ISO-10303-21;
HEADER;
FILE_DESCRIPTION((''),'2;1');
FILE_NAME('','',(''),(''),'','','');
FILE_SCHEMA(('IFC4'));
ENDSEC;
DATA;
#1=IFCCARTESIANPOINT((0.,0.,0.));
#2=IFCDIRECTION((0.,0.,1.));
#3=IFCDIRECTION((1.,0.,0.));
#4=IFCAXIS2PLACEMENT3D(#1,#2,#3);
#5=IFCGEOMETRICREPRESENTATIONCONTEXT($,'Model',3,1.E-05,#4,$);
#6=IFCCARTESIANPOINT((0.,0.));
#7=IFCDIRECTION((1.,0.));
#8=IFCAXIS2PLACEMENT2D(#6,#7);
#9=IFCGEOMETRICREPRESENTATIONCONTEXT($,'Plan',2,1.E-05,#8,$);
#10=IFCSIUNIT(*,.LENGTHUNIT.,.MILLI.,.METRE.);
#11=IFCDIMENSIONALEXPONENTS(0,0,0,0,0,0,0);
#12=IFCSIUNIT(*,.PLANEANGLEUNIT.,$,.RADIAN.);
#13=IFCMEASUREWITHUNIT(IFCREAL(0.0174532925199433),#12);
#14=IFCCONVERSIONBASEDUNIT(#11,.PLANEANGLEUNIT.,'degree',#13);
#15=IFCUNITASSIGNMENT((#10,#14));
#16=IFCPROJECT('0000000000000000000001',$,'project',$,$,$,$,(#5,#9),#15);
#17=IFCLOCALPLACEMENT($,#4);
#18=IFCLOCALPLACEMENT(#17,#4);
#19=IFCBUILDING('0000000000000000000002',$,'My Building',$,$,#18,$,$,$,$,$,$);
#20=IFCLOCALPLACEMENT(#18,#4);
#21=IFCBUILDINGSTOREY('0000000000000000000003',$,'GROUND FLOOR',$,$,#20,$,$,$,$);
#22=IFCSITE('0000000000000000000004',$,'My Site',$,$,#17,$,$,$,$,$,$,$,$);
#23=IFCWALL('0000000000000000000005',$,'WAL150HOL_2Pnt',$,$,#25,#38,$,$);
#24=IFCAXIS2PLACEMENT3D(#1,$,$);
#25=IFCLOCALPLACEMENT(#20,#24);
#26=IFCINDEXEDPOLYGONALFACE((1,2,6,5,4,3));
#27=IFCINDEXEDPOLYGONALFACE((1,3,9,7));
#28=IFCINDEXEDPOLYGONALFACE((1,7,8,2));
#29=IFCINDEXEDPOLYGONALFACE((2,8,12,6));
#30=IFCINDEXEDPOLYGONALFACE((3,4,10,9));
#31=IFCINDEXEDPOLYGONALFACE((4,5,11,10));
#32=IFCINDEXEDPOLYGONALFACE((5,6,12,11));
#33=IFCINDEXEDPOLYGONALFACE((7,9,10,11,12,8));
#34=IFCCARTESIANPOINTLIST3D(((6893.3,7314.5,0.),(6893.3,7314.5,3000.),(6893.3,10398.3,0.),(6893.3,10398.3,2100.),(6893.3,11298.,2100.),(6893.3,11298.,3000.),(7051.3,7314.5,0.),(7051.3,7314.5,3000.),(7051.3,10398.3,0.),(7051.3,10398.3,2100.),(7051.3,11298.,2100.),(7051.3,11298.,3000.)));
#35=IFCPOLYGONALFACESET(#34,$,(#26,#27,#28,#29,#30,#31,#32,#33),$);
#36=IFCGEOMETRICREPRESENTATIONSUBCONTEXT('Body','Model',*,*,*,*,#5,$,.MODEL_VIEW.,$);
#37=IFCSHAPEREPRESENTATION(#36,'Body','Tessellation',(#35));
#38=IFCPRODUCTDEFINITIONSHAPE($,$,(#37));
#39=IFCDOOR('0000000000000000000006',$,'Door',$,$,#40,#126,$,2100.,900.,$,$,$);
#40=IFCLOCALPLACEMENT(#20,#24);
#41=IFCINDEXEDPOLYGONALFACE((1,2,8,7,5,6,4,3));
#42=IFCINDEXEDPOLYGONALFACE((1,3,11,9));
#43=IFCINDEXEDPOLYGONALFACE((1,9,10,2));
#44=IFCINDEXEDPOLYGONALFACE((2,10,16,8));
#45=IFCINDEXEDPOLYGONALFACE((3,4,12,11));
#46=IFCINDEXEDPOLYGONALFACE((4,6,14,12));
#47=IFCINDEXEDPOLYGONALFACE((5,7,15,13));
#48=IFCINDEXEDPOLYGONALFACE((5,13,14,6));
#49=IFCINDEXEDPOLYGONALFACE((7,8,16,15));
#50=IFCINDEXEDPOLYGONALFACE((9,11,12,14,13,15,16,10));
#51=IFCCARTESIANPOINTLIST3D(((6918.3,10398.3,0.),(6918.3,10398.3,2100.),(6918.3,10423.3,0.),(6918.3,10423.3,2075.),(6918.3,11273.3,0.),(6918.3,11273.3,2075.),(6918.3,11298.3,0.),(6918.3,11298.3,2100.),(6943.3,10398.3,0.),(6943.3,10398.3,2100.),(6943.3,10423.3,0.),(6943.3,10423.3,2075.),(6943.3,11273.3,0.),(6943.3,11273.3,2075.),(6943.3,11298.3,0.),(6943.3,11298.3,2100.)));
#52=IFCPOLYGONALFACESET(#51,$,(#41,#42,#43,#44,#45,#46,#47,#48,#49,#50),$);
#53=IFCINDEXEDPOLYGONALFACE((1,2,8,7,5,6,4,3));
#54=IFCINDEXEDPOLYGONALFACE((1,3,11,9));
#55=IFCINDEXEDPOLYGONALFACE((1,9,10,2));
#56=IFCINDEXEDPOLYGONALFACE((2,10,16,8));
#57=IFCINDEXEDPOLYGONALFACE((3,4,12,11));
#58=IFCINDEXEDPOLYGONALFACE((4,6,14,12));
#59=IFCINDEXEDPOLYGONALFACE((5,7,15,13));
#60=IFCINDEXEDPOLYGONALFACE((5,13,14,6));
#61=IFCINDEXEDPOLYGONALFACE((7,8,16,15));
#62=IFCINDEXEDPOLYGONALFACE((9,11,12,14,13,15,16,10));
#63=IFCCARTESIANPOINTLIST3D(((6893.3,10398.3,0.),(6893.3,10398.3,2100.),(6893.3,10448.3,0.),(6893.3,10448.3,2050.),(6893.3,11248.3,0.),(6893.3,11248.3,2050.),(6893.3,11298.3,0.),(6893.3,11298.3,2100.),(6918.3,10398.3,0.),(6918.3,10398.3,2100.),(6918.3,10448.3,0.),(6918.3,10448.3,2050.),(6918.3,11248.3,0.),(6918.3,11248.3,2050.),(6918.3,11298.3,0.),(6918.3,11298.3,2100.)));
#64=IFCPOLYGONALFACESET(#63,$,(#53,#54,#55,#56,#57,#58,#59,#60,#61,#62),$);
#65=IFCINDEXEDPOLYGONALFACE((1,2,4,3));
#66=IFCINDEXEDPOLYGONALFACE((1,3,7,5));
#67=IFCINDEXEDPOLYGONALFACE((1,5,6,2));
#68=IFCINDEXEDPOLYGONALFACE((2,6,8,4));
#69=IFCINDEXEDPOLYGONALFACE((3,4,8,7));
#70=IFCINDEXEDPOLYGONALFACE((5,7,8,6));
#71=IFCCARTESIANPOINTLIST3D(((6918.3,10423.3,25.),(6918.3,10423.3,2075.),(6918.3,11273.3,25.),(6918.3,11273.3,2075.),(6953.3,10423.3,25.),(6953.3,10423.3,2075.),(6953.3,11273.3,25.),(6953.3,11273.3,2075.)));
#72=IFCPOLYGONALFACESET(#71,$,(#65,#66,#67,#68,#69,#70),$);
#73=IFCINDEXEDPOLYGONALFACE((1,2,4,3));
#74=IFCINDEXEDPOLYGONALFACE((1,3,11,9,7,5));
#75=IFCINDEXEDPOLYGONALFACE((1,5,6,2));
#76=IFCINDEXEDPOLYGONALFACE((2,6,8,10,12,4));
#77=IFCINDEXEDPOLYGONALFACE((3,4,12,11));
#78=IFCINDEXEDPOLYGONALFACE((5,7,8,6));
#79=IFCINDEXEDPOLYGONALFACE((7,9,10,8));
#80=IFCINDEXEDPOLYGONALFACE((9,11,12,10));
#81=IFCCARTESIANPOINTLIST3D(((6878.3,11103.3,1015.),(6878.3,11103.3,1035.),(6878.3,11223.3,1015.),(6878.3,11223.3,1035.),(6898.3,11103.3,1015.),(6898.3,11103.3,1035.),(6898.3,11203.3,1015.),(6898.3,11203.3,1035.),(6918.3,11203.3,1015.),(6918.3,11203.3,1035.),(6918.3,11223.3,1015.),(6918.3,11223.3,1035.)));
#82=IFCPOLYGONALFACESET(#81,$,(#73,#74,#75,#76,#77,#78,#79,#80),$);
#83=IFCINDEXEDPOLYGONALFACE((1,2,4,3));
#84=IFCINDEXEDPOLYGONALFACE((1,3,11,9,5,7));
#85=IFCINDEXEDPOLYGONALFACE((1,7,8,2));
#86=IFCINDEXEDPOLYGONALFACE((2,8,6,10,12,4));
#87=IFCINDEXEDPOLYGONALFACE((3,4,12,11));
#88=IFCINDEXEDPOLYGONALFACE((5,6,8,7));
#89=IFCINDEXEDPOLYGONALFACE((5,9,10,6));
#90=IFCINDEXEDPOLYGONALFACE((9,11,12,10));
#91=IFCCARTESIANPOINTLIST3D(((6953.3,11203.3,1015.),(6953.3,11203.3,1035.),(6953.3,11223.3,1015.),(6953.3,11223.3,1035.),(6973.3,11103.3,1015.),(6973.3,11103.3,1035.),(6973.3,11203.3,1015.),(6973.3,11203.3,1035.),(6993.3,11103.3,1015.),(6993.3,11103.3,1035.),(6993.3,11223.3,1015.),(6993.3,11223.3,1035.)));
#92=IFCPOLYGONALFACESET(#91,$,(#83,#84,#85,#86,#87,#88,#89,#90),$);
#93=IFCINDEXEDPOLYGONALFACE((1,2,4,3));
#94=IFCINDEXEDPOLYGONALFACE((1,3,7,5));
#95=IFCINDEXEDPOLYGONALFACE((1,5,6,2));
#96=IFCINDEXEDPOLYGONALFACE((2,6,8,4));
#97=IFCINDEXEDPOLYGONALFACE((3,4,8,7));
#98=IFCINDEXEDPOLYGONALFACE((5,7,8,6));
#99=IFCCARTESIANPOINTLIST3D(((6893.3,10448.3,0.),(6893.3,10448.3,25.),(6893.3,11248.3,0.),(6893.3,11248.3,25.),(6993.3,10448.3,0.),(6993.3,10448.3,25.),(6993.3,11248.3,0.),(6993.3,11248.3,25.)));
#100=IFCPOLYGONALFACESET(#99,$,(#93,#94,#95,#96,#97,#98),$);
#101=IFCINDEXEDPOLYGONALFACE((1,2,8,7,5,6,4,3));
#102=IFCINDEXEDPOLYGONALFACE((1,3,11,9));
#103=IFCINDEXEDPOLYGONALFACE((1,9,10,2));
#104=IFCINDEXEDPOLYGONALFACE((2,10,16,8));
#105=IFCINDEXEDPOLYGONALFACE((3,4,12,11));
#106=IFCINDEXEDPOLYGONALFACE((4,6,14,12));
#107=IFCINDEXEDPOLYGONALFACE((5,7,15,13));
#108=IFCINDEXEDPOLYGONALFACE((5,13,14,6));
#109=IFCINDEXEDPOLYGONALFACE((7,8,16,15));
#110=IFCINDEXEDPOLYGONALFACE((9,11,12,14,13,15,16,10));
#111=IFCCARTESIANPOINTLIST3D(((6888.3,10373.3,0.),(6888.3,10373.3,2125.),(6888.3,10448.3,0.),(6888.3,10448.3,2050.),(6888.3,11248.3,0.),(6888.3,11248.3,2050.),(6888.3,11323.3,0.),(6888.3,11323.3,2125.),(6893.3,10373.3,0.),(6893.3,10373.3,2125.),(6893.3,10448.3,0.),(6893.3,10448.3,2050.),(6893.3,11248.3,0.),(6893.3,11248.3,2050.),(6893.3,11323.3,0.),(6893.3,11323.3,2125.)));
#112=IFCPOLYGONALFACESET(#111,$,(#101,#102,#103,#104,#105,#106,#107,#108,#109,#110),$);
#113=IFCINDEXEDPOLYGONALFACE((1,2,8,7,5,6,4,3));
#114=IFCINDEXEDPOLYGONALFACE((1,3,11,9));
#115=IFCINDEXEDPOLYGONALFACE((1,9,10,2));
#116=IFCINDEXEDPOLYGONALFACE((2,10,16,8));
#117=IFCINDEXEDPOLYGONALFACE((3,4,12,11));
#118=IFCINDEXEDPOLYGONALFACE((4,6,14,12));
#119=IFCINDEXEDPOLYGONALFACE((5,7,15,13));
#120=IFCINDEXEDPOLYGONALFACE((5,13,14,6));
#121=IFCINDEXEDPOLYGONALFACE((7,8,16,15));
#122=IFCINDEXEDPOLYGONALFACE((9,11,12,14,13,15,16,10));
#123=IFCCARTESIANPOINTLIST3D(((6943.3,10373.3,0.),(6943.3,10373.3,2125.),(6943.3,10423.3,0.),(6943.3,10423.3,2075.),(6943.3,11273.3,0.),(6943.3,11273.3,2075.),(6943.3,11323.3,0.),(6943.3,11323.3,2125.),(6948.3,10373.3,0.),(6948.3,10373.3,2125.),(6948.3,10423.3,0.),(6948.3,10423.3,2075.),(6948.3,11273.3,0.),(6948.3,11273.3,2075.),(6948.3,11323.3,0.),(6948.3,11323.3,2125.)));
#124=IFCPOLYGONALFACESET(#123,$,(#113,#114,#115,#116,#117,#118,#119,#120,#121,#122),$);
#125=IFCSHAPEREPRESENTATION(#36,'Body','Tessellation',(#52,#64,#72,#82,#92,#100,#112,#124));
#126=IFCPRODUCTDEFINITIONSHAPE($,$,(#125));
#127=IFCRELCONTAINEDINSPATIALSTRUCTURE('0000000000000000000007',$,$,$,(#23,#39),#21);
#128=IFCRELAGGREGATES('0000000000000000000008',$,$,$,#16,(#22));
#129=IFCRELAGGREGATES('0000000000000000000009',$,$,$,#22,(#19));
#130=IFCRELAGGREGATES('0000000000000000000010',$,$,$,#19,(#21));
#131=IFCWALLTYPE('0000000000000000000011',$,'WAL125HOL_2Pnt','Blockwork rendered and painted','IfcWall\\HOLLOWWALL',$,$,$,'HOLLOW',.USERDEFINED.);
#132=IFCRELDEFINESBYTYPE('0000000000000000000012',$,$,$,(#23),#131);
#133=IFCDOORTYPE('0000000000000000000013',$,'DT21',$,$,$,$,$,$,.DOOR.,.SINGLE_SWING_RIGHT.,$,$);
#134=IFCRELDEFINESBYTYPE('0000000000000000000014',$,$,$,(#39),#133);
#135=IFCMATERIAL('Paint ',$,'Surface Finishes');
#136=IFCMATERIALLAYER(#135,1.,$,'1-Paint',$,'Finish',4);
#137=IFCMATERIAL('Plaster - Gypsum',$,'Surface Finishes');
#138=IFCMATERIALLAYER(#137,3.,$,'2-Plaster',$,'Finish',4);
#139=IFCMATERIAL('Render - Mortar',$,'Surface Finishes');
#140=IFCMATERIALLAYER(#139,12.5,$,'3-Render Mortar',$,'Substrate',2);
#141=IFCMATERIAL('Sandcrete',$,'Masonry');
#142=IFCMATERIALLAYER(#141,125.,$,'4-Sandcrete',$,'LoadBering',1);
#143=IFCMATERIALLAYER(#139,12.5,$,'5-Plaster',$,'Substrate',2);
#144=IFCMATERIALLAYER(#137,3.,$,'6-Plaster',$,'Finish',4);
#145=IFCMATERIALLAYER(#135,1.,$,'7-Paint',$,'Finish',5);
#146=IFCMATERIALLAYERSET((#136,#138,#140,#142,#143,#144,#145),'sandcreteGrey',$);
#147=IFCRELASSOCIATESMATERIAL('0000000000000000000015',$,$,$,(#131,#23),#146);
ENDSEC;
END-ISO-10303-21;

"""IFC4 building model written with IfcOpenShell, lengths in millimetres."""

from ifc_helpers import new_model, entity, si_unit, converted_unit, frame, origin_with_axes, origin_2d_with_axis, place, context, subcontext, project, spatial, line, indexed_curve, outline, extrude, shape, source, transform, mapped, material, layer, layer_set, layer_usage, type_object, type_shapes, element, fill, save


model = new_model("IFC4")

# Units and contexts
model_context = context("Model", 3, precision=1e-05, world=origin_with_axes())
plan_context = context("Plan", 2, precision=1e-05, world=origin_2d_with_axis())
body_context_1 = subcontext(model_context, "Body", "Model", "MODEL_VIEW")
body_context_2 = subcontext(plan_context, "Body", "Plan", "PLAN_VIEW")
ifc_project = project(units=[si_unit("LENGTHUNIT", "METRE", prefix="MILLI"), converted_unit("PLANEANGLEUNIT", "degree", entity("IfcReal", 0.0174532925199433), si_unit("PLANEANGLEUNIT", "RADIAN"), dimensions=[0, 0, 0, 0, 0, 0, 0])], contexts=[model_context, plan_context])

# Site, building, storey
site_placement = place(None, origin_with_axes())
site = spatial("IfcSite", under=ifc_project, at=site_placement, Name="My Site")
building_placement = place(site_placement, origin_with_axes())
building = spatial("IfcBuilding", under=site, at=building_placement, Name="My Building")
storey_placement = place(building_placement, origin_with_axes())
storey = spatial("IfcBuildingStorey", under=building, at=storey_placement, Name="GROUND FLOOR")

# Shared definitions
shared_shape_1 = source(origin_with_axes(), body_context_1, "Body", "SweptSolid", [
    extrude(outline(indexed_curve([(0.0, 0.0), (900.0, 0.0), (900.0, 2100.0), (0.0, 2100.0)], segments=[line(1, 2, 3, 4, 1)])), frame((0.0, -600.0, 0.0), z_axis=(0.0, -1.0, 0.0), x_axis=(1.0, 0.0, 0.0)), (0.0, 0.0, -1.0), 1200.0),
])
door_type_1 = type_object("IfcDoorType", Name="DT21", OperationType="SINGLE_SWING_RIGHT", PredefinedType="DOOR")
shared_shape_2 = source(origin_with_axes(), body_context_1, "Body", "SweptSolid", [
    extrude(outline(indexed_curve([(0.0, 0.0), (0.0, 2100.0), (900.0, 2100.0), (900.0, 0.0), (875.0, 0.0), (875.0, 2075.0), (25.0, 2075.0), (25.0, 0.0)], segments=[line(1, 2, 3, 4, 5, 6, 7, 8, 1)])), frame((0.0, 25.0, 0.0), z_axis=(0.0, -1.0, 0.0), x_axis=(1.0, 0.0, 0.0)), (0.0, 0.0, -1.0), 25.0),
    extrude(outline(indexed_curve([(0.0, 0.0), (0.0, 2100.0), (900.0, 2100.0), (900.0, 0.0), (850.0, 0.0), (850.0, 2050.0), (50.0, 2050.0), (50.0, 0.0)], segments=[line(1, 2, 3, 4, 5, 6, 7, 8, 1)])), frame((0.0, 0.0, 0.0), z_axis=(0.0, -1.0, 0.0), x_axis=(1.0, 0.0, 0.0)), (0.0, 0.0, -1.0), 25.0),
    extrude(outline(indexed_curve([(0.0, 0.0), (850.0, 0.0), (850.0, 35.0), (0.0, 35.0)], segments=[line(1, 2, 3, 4, 1)])), frame((25.0, 25.0, 25.0), z_axis=(0.0, 0.0, 1.0), x_axis=(1.0, 0.0, 0.0)), (0.0, 0.0, 1.0), 2050.0),
    extrude(outline(indexed_curve([(0.0, 0.0), (0.0, -40.0), (120.0, -40.0), (120.0, -20.0), (20.0, -20.0), (20.0, 0.0)], segments=[line(1, 2, 3, 4, 5, 6, 1)])), frame((75.0, 25.0, 1015.0), z_axis=(0.0, 0.0, 1.0), x_axis=(1.0, 0.0, 0.0)), (0.0, 0.0, 1.0), 20.0),
    extrude(outline(indexed_curve([(0.0, 0.0), (0.0, 40.0), (120.0, 40.0), (120.0, 20.0), (20.0, 20.0), (20.0, 0.0)], segments=[line(1, 2, 3, 4, 5, 6, 1)])), frame((75.0, 60.0, 1015.0), z_axis=(0.0, 0.0, 1.0), x_axis=(1.0, 0.0, 0.0)), (0.0, 0.0, 1.0), 20.0),
    extrude(outline(indexed_curve([(0.0, 0.0), (800.0, 0.0), (800.0, 100.0), (0.0, 100.0)], segments=[line(1, 2, 3, 4, 1)])), frame((50.0, 0.0, 0.0), z_axis=(0.0, 0.0, 1.0), x_axis=(1.0, 0.0, 0.0)), (0.0, 0.0, 1.0), 25.0),
    extrude(outline(indexed_curve([(0.0, 0.0), (0.0, 2125.0), (950.0, 2125.0), (950.0, 0.0), (875.0, 0.0), (875.0, 2050.0), (75.0, 2050.0), (75.0, 0.0)], segments=[line(1, 2, 3, 4, 5, 6, 7, 8, 1)])), frame((-25.0, -5.0, 0.0), z_axis=(0.0, -1.0, 0.0), x_axis=(1.0, 0.0, 0.0)), (0.0, 0.0, -1.0), 5.0),
    extrude(outline(indexed_curve([(0.0, 0.0), (0.0, 2125.0), (950.0, 2125.0), (950.0, 0.0), (900.0, 0.0), (900.0, 2075.0), (50.0, 2075.0), (50.0, 0.0)], segments=[line(1, 2, 3, 4, 5, 6, 7, 8, 1)])), frame((-25.0, 50.0, 0.0), z_axis=(0.0, -1.0, 0.0), x_axis=(1.0, 0.0, 0.0)), (0.0, 0.0, -1.0), 5.0),
])
shared_shape_3 = source(origin_with_axes(), body_context_2, "Body", "Curve2D", [
    entity("IfcIndexedPolyCurve", entity("IfcCartesianPointList2D", [[0.0, 0.0], [0.0, 50.0], [25.0, 50.0], [25.0, 25.0], [50.0, 25.0], [50.0, 0.0]]), [entity("IfcLineIndex", [1, 2, 3, 4, 5, 6, 1])]),
    entity("IfcIndexedPolyCurve", entity("IfcCartesianPointList2D", [[900.0, 0.0], [900.0, 50.0], [875.0, 50.0], [875.0, 25.0], [850.0, 25.0], [850.0, 0.0]]), [entity("IfcLineIndex", [1, 2, 3, 4, 5, 6, 1])]),
    entity("IfcTrimmedCurve", entity("IfcEllipse", entity("IfcAxis2Placement2D", entity("IfcCartesianPoint", [840.0, 50.0]), entity("IfcDirection", [1.0, 0.0])), 815.0, 850.0), [entity("IfcCartesianPoint", [840.0, 900.0])], [entity("IfcCartesianPoint", [25.0, 50.0])], True, "CARTESIAN"),
    entity("IfcIndexedPolyCurve", entity("IfcCartesianPointList2D", [[875.0, 50.0], [840.0, 50.0], [840.0, 900.0], [875.0, 900.0]]), [entity("IfcLineIndex", [1, 2, 3, 4, 1])]),
])
type_shapes(door_type_1, [shared_shape_2, shared_shape_3])

# Wall, opening, door
ifc_material_1 = material(Name="Paint ", Category="Surface Finishes")
ifc_layer_1 = layer(ifc_material_1, 1.0, Name="1-Paint", Category="Finish", Priority=4)
ifc_material_2 = material(Name="Plaster - Gypsum", Category="Surface Finishes")
ifc_layer_2 = layer(ifc_material_2, 3.0, Name="2-Plaster", Category="Finish", Priority=4)
ifc_material_3 = material(Name="Render - Mortar", Category="Surface Finishes")
ifc_layer_3 = layer(ifc_material_3, 12.5, Name="3-Render Mortar", Category="Substrate", Priority=2)
ifc_material_4 = material(Name="Sandcrete", Category="Masonry")
ifc_layer_4 = layer(ifc_material_4, 125.0, Name="4-Sandcrete", Category="LoadBering", Priority=1)
ifc_layer_5 = layer(ifc_material_3, 12.5, Name="5-Plaster", Category="Substrate", Priority=2)
ifc_layer_6 = layer(ifc_material_2, 3.0, Name="6-Plaster", Category="Finish", Priority=4)
ifc_layer_7 = layer(ifc_material_1, 1.0, Name="7-Paint", Category="Finish", Priority=5)
ifc_layer_set_1 = layer_set([ifc_layer_1, ifc_layer_2, ifc_layer_3, ifc_layer_4, ifc_layer_5, ifc_layer_6, ifc_layer_7], Name="sandcreteGrey")
ifc_layer_usage_1 = layer_usage(ifc_layer_set_1, "AXIS2", "POSITIVE", 0.0)
wall_type_1 = type_object("IfcWallType", Name="WAL125HOL_2Pnt", Description="Blockwork rendered and painted", ApplicableOccurrence="IfcWall\\HOLLOWWALL", ElementType="HOLLOW", PredefinedType="USERDEFINED", material=ifc_layer_set_1)
wall_1_placement = place(storey_placement, frame((6893.3, 11298.0, 0.0), z_axis=(0.0, 0.0, 1.0), x_axis=(-0.000001, -1.0, 0.0)))
wall_1 = element("IfcWall", 1, at=wall_1_placement, inside=storey, type_object=wall_type_1, material=ifc_layer_usage_1, Name="WAL150HOL_2Pnt", context=body_context_1, shape_type="SweptSolid", body=[
    extrude(outline(indexed_curve([(0.0, 0.0), (0.0, 158.0), (3983.5, 158.0), (3983.5, 0.0), (0.0, 0.0)], self_intersect=False)), origin_with_axes(), (0.0, 0.0, 1.0), 3000.0),
])
opening_1_placement = place(wall_1_placement, frame((-0.3, 0.0, 0.0), z_axis=(0.0, 0.0, 1.0), x_axis=(1.0, 0.0, 0.0)))
opening_1 = element("IfcOpeningElement", 2, at=opening_1_placement, cuts=wall_1, PredefinedType="OPENING", context=body_context_1, shape_type="MappedRepresentation", body=[
    mapped(shared_shape_1, transform((0.0, 0.0, 0.0), x_axis=(1.0, 0.0, 0.0), y_axis=(0.0, 1.0, 0.0), z_axis=(0.0, 0.0, 1.0), scale=1.0)),
])
door_1_placement = place(opening_1_placement, origin_with_axes())
door_1 = element("IfcDoor", 3, at=door_1_placement, inside=storey, type_object=door_type_1, Name="Door", OverallHeight=2100.0, OverallWidth=900.0, shapes=[
    shape(body_context_1, "Body", "MappedRepresentation", [mapped(shared_shape_2, transform((0.0, 0.0, 0.0), x_axis=(1.0, 0.0, 0.0), y_axis=(0.0, 1.0, 0.0), z_axis=(0.0, 0.0, 1.0), scale=1.0))]),
    shape(body_context_2, "Body", "MappedRepresentation", [mapped(shared_shape_3, transform((0.0, 0.0, 0.0), x_axis=(1.0, 0.0, 0.0), y_axis=(0.0, 1.0, 0.0), z_axis=(0.0, 0.0, 1.0), scale=1.0))]),
])
fill(opening_1, door_1)

save(model, "model.ifc")
